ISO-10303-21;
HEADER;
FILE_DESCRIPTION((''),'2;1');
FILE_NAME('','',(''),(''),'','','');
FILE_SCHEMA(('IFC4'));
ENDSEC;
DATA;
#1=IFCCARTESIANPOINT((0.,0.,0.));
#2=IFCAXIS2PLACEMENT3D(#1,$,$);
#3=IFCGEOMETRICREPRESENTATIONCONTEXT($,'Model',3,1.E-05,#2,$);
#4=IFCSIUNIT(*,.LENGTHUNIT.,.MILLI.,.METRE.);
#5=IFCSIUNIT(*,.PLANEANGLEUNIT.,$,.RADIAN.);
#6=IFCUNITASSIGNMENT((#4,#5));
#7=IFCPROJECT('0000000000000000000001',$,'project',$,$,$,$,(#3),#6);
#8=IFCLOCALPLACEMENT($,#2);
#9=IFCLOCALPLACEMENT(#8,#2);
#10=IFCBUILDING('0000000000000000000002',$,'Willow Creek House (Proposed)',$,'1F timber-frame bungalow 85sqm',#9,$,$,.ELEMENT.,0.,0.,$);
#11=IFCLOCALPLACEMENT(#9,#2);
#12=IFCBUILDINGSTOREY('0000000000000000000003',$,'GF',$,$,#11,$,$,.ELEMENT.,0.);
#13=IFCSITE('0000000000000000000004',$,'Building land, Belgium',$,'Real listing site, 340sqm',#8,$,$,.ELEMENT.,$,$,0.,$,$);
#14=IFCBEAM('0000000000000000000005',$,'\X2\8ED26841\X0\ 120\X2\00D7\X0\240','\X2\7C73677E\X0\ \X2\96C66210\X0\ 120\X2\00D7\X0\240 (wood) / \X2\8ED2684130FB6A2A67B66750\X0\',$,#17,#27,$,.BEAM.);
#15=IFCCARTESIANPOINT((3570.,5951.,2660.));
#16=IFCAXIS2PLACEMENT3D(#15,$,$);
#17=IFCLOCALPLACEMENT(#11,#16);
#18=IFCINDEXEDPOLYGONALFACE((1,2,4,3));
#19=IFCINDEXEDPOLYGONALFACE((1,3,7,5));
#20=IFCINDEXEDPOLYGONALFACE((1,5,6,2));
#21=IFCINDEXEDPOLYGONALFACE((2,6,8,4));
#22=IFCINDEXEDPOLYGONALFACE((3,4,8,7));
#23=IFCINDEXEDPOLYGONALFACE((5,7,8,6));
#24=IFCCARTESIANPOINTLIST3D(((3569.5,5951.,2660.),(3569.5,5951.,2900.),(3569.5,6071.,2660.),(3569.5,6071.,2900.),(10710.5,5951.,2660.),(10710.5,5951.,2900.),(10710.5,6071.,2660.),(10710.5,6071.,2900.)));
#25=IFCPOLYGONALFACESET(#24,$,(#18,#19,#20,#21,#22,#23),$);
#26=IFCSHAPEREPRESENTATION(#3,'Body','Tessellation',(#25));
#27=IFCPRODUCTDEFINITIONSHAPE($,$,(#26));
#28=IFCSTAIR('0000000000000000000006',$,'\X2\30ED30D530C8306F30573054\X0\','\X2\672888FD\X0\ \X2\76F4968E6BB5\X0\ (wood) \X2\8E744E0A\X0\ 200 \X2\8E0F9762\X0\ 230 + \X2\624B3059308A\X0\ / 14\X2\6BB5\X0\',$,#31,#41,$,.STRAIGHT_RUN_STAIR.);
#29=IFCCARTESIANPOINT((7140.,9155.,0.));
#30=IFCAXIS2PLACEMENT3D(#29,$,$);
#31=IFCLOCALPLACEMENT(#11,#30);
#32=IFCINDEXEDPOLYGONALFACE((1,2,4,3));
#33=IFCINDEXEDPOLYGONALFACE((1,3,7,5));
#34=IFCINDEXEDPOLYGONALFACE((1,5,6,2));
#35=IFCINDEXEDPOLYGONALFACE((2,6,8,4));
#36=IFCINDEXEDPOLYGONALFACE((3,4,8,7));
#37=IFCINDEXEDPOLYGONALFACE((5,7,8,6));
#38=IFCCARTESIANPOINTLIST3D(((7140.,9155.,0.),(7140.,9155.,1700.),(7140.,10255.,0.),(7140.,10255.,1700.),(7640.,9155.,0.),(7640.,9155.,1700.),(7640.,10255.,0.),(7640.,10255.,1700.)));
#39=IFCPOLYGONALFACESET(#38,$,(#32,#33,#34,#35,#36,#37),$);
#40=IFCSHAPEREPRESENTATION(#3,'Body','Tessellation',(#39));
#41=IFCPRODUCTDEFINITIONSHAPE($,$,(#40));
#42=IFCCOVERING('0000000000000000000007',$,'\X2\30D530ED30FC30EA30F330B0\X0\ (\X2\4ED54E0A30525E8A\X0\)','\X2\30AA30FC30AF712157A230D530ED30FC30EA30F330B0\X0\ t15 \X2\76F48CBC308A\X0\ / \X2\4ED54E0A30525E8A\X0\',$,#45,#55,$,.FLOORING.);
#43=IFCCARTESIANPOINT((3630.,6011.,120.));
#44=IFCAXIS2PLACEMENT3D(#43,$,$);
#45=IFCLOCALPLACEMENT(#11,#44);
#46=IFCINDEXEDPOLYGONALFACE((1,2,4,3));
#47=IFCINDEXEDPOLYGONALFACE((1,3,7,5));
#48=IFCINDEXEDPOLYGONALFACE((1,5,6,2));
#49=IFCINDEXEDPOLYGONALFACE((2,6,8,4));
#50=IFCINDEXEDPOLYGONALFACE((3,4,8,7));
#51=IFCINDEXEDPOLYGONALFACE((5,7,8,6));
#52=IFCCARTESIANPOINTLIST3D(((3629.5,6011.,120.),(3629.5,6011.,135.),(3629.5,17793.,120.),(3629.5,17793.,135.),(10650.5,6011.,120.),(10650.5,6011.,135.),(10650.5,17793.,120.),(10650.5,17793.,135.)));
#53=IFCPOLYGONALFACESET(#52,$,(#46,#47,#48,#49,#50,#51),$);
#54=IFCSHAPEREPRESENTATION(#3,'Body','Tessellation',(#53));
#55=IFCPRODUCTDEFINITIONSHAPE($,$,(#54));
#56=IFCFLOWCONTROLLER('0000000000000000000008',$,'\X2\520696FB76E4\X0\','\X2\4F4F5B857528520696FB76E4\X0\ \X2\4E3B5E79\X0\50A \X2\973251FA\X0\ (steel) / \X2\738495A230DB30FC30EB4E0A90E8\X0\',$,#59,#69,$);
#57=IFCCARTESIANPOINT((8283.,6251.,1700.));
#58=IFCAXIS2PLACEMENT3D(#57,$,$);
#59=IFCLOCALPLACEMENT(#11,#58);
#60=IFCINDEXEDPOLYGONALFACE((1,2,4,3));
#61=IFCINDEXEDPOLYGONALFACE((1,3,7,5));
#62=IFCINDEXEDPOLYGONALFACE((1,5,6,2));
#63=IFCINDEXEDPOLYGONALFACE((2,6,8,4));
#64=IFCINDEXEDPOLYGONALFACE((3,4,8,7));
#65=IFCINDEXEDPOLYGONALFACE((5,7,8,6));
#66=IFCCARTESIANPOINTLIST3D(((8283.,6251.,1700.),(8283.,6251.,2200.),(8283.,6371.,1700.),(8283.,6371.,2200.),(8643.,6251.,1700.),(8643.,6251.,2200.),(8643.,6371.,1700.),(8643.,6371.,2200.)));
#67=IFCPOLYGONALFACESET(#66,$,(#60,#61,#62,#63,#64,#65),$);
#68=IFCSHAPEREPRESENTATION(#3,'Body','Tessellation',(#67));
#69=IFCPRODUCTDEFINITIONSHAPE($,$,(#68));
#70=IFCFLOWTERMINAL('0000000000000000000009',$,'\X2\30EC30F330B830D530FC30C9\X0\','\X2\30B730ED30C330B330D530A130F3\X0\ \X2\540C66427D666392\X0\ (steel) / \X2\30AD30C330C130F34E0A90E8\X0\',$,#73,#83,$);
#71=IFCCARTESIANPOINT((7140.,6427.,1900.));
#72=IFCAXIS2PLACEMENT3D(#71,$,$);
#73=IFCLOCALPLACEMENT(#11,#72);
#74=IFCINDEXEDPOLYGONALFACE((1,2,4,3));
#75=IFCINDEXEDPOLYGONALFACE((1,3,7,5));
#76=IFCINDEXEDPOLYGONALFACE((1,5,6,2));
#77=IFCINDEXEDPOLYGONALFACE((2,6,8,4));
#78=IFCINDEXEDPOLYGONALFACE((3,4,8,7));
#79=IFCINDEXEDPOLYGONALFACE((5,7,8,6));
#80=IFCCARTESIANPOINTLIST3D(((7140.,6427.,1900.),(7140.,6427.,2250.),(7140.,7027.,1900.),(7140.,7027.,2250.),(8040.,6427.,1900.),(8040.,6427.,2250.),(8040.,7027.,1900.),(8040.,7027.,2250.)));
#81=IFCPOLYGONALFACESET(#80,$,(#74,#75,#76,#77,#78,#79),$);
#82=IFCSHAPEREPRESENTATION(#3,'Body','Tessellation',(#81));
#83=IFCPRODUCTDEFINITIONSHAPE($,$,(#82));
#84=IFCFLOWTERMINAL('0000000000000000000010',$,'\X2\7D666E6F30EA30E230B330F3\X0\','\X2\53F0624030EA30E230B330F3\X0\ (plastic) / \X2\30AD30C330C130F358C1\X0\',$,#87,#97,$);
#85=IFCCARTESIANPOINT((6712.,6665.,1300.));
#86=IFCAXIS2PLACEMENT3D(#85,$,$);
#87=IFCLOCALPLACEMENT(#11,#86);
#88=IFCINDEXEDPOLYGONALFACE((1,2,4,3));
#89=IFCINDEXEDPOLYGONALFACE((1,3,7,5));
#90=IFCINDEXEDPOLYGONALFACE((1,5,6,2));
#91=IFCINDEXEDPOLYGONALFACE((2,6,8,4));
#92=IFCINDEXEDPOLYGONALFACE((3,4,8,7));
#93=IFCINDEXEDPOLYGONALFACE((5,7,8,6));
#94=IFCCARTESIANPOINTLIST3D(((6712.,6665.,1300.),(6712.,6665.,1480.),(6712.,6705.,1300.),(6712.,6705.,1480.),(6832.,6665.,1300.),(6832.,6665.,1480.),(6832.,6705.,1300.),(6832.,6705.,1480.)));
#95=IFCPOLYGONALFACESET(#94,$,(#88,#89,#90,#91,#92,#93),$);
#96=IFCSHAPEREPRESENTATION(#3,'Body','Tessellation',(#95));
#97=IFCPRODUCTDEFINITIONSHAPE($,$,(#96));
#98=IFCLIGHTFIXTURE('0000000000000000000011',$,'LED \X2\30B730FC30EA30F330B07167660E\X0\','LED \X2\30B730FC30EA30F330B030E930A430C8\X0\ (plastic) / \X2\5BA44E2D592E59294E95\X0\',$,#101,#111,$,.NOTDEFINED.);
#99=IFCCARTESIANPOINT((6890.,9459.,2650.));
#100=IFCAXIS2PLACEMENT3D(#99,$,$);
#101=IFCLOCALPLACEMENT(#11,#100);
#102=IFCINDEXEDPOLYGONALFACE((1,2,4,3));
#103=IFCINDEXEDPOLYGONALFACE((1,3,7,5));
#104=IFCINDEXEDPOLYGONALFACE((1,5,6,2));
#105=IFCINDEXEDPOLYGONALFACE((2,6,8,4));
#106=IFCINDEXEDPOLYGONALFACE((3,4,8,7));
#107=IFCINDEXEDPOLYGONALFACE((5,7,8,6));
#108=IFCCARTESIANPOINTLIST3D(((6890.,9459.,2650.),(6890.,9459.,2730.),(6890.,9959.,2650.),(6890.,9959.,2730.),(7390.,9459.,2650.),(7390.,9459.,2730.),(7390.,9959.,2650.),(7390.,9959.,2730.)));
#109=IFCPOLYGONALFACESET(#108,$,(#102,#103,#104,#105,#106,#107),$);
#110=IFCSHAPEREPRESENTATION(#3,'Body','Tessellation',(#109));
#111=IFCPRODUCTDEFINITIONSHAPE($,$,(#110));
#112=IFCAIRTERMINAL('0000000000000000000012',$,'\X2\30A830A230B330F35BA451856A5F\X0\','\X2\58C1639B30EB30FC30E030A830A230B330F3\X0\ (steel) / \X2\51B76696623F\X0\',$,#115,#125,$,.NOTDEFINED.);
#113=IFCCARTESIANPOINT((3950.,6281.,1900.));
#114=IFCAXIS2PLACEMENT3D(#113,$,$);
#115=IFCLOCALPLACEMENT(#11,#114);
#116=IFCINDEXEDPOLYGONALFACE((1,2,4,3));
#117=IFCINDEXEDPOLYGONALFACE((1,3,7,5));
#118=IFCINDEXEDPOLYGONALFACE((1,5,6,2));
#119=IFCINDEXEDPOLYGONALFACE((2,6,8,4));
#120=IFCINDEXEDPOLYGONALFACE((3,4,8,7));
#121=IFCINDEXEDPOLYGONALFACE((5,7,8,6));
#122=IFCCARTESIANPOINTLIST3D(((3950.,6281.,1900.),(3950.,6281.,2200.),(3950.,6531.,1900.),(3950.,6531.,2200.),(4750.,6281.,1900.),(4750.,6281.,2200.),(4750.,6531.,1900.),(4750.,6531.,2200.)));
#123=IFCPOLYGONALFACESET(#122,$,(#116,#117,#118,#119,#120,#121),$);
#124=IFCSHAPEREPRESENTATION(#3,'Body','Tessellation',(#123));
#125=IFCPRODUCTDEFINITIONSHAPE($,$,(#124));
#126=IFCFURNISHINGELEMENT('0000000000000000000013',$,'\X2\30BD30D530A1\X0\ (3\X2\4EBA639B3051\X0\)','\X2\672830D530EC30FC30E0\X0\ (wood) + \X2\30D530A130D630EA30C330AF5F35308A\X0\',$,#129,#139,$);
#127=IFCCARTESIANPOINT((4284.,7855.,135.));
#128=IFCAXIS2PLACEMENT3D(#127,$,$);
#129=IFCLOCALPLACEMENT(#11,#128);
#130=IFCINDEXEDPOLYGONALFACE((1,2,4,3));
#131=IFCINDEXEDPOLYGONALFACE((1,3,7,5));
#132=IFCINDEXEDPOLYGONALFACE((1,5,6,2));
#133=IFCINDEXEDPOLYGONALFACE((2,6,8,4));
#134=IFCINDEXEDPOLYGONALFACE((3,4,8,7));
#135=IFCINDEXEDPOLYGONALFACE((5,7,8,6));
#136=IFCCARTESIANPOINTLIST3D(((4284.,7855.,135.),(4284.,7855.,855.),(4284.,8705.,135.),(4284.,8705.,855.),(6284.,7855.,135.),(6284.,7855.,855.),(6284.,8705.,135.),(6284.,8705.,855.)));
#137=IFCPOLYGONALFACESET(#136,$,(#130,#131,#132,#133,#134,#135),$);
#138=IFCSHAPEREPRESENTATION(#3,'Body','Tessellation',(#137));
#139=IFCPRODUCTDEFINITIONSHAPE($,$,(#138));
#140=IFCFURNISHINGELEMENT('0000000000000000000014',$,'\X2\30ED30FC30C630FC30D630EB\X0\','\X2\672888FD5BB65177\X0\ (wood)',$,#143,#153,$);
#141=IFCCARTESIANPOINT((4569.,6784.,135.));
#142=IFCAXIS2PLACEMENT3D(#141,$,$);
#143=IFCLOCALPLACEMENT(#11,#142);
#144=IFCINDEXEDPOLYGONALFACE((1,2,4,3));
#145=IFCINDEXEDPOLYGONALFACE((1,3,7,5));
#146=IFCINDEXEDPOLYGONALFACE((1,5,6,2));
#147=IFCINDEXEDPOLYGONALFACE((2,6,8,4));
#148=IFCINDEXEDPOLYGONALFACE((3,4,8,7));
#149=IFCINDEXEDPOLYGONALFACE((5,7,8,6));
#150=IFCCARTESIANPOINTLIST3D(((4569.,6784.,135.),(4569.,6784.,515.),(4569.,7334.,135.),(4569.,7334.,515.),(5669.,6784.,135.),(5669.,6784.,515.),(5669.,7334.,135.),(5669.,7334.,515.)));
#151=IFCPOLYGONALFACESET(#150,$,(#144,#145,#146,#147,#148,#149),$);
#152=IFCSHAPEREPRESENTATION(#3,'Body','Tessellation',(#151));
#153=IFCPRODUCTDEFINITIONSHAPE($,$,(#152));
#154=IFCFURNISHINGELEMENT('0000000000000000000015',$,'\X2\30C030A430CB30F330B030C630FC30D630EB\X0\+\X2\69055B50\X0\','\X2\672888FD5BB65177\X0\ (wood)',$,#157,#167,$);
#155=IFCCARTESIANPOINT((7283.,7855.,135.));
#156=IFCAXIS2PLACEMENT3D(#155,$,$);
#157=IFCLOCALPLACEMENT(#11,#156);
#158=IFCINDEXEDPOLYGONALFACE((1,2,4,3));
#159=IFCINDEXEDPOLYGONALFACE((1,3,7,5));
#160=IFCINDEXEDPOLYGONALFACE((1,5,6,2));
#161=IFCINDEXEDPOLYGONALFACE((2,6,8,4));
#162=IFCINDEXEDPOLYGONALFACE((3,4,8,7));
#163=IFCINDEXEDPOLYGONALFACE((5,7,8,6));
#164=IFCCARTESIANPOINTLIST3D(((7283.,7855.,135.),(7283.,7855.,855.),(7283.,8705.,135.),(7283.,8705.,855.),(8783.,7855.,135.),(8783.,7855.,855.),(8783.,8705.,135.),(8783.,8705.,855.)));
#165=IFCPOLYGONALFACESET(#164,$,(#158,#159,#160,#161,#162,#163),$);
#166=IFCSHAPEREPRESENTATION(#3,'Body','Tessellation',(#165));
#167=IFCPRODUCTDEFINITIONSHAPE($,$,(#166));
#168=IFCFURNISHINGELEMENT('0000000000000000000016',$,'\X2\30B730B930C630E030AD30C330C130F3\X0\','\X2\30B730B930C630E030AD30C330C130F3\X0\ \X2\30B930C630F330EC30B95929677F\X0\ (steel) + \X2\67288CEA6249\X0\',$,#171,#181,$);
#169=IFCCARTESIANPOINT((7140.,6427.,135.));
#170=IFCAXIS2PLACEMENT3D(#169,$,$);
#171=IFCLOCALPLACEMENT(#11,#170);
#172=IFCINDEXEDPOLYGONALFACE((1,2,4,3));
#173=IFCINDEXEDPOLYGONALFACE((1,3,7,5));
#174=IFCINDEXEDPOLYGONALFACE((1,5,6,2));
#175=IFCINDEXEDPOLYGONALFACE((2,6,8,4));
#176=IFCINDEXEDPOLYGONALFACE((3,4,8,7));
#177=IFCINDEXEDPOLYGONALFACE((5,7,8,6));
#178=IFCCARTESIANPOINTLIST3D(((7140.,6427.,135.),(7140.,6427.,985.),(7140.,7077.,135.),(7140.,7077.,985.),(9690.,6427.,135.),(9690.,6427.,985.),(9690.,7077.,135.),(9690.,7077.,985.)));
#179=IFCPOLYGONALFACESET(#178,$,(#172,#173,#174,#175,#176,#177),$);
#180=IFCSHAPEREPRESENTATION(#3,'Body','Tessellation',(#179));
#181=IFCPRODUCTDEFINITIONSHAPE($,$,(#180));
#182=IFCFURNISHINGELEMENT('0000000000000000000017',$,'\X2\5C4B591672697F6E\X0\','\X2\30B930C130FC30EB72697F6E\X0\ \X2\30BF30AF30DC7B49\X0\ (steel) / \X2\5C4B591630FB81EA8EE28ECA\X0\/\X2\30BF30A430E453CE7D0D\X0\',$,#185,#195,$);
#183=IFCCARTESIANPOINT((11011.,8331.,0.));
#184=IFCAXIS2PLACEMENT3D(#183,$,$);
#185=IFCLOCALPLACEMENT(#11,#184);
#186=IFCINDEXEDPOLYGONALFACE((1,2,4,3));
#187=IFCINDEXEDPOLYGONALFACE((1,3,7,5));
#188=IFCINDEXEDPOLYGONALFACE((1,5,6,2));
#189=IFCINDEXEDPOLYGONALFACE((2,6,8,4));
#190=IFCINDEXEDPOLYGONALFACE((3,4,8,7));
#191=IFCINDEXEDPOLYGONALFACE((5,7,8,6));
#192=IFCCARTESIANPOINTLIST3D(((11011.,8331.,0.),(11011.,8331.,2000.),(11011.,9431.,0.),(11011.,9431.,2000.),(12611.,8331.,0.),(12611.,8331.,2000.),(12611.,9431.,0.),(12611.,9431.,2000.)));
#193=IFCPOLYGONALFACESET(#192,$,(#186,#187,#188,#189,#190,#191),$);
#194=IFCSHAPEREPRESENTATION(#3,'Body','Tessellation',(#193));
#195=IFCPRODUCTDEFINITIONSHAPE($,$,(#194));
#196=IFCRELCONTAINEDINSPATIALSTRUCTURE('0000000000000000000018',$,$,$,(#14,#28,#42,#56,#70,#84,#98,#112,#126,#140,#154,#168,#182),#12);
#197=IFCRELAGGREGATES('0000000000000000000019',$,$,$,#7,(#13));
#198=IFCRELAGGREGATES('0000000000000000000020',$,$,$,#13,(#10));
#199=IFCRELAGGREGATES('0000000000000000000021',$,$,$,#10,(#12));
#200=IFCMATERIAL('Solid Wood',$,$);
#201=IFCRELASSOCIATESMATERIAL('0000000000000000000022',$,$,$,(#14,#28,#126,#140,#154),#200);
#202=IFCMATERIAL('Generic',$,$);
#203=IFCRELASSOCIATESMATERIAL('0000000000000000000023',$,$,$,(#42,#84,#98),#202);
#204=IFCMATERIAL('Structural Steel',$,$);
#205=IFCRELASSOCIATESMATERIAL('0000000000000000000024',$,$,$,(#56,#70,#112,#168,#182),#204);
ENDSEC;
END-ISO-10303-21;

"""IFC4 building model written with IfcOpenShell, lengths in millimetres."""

from ifc_helpers import new_model, si_unit, frame, frame_2d, origin, place, context, project, spatial, rectangle, extrude, material, element, save


model = new_model("IFC4")

# Units and contexts
model_context = context("Model", 3, precision=1e-05, world=origin())
ifc_project = project(units=[si_unit("LENGTHUNIT", "METRE", prefix="MILLI"), si_unit("PLANEANGLEUNIT", "RADIAN")], contexts=[model_context])

# Site, building, storey
site_placement = place(None, origin())
site = spatial("IfcSite", under=ifc_project, at=site_placement, Name="Building land, Belgium", ObjectType="Real listing site, 340sqm", CompositionType="ELEMENT", RefElevation=0.0)
building_placement = place(site_placement, origin())
building = spatial("IfcBuilding", under=site, at=building_placement, Name="Willow Creek House (Proposed)", ObjectType="1F timber-frame bungalow 85sqm", CompositionType="ELEMENT", ElevationOfRefHeight=0.0, ElevationOfTerrain=0.0)
storey_placement = place(building_placement, origin())
storey = spatial("IfcBuildingStorey", under=building, at=storey_placement, Name="GF", CompositionType="ELEMENT", Elevation=0.0)

# Shared definitions
ifc_material_1 = material(Name="Solid Wood")

# Beam
beam_1_placement = place(storey_placement, frame((3570.0, 5951.0, 2660.0)))
element("IfcBeam", 1, at=beam_1_placement, inside=storey, material=ifc_material_1, Name="軒桁 120×240", Description="米松 集成 120×240 (wood) / 軒桁・横架材", PredefinedType="BEAM", context=model_context, shape_type="SweptSolid", body=[
    extrude(rectangle(XDim=7141.0, YDim=120.0, at=frame_2d((3570.0, 60.0))), frame((3570.0, 5951.0, 2660.0)), (0.0, 0.0, 1.0), 240.0),
])

# Stair
stair_placement = place(storey_placement, frame((7140.0, 9155.0, 0.0)))
element("IfcStair", 2, at=stair_placement, inside=storey, material=ifc_material_1, Name="ロフトはしご", Description="木製 直階段 (wood) 蹴上 200 踏面 230 + 手すり / 14段", PredefinedType="STRAIGHT_RUN_STAIR", context=model_context, shape_type="SweptSolid", body=[
    extrude(rectangle(XDim=500.0, YDim=1100.0, at=frame_2d((250.0, 550.0))), frame((7140.0, 9155.0, 0.0)), (0.0, 0.0, 1.0), 1700.0),
])

# Covering
ifc_material_2 = material(Name="Generic")
covering_placement = place(storey_placement, frame((3630.0, 6011.0, 120.0)))
element("IfcCovering", 3, at=covering_placement, inside=storey, material=ifc_material_2, Name="フローリング (仕上げ床)", Description="オーク無垢フローリング t15 直貼り / 仕上げ床", PredefinedType="FLOORING", context=model_context, shape_type="SweptSolid", body=[
    extrude(rectangle(XDim=7021.0, YDim=11782.0, at=frame_2d((3510.0, 5891.0))), frame((3630.0, 6011.0, 120.0)), (0.0, 0.0, 1.0), 15.0),
])

# Flow controller
ifc_material_3 = material(Name="Structural Steel")
flow_controller_placement = place(storey_placement, frame((8283.0, 6251.0, 1700.0)))
element("IfcFlowController", 4, at=flow_controller_placement, inside=storey, material=ifc_material_3, Name="分電盤", Description="住宅用分電盤 主幹50A 露出 (steel) / 玄関ホール上部", context=model_context, shape_type="SweptSolid", body=[
    extrude(rectangle(XDim=360.0, YDim=120.0, at=frame_2d((180.0, 60.0))), frame((8283.0, 6251.0, 1700.0)), (0.0, 0.0, 1.0), 500.0),
])

# Flow terminals
flow_terminal_1_placement = place(storey_placement, frame((7140.0, 6427.0, 1900.0)))
element("IfcFlowTerminal", 5, at=flow_terminal_1_placement, inside=storey, material=ifc_material_3, Name="レンジフード", Description="シロッコファン 同時給排 (steel) / キッチン上部", context=model_context, shape_type="SweptSolid", body=[
    extrude(rectangle(XDim=900.0, YDim=600.0, at=frame_2d((450.0, 300.0))), frame((7140.0, 6427.0, 1900.0)), (0.0, 0.0, 1.0), 350.0),
])
flow_terminal_2_placement = place(storey_placement, frame((6712.0, 6665.0, 1300.0)))
element("IfcFlowTerminal", 6, at=flow_terminal_2_placement, inside=storey, material=ifc_material_2, Name="給湯リモコン", Description="台所リモコン (plastic) / キッチン壁", context=model_context, shape_type="SweptSolid", body=[
    extrude(rectangle(XDim=120.0, YDim=40.0, at=frame_2d((60.0, 20.0))), frame((6712.0, 6665.0, 1300.0)), (0.0, 0.0, 1.0), 180.0),
])

# Light fixture
light_fixture_placement = place(storey_placement, frame((6890.0, 9459.0, 2650.0)))
element("IfcLightFixture", 7, at=light_fixture_placement, inside=storey, material=ifc_material_2, Name="LED シーリング照明", Description="LED シーリングライト (plastic) / 室中央天井", PredefinedType="NOTDEFINED", context=model_context, shape_type="SweptSolid", body=[
    extrude(rectangle(XDim=500.0, YDim=500.0, at=frame_2d((250.0, 250.0))), frame((6890.0, 9459.0, 2650.0)), (0.0, 0.0, 1.0), 80.0),
])

# Air terminal
air_terminal_placement = place(storey_placement, frame((3950.0, 6281.0, 1900.0)))
element("IfcAirTerminal", 8, at=air_terminal_placement, inside=storey, material=ifc_material_3, Name="エアコン室内機", Description="壁掛ルームエアコン (steel) / 冷暖房", PredefinedType="NOTDEFINED", context=model_context, shape_type="SweptSolid", body=[
    extrude(rectangle(XDim=800.0, YDim=250.0, at=frame_2d((400.0, 125.0))), frame((3950.0, 6281.0, 1900.0)), (0.0, 0.0, 1.0), 300.0),
])

# Furnishing elements
furnishing_1_placement = place(storey_placement, frame((4284.0, 7855.0, 135.0)))
element("IfcFurnishingElement", 9, at=furnishing_1_placement, inside=storey, material=ifc_material_1, Name="ソファ (3人掛け)", Description="木フレーム (wood) + ファブリック張り", context=model_context, shape_type="SweptSolid", body=[
    extrude(rectangle(XDim=2000.0, YDim=850.0, at=frame_2d((1000.0, 425.0))), frame((4284.0, 7855.0, 135.0)), (0.0, 0.0, 1.0), 720.0),
])
furnishing_2_placement = place(storey_placement, frame((4569.0, 6784.0, 135.0)))
element("IfcFurnishingElement", 10, at=furnishing_2_placement, inside=storey, material=ifc_material_1, Name="ローテーブル", Description="木製家具 (wood)", context=model_context, shape_type="SweptSolid", body=[
    extrude(rectangle(XDim=1100.0, YDim=550.0, at=frame_2d((550.0, 275.0))), frame((4569.0, 6784.0, 135.0)), (0.0, 0.0, 1.0), 380.0),
])
furnishing_3_placement = place(storey_placement, frame((7283.0, 7855.0, 135.0)))
element("IfcFurnishingElement", 11, at=furnishing_3_placement, inside=storey, material=ifc_material_1, Name="ダイニングテーブル+椅子", Description="木製家具 (wood)", context=model_context, shape_type="SweptSolid", body=[
    extrude(rectangle(XDim=1500.0, YDim=850.0, at=frame_2d((750.0, 425.0))), frame((7283.0, 7855.0, 135.0)), (0.0, 0.0, 1.0), 720.0),
])
furnishing_4_placement = place(storey_placement, frame((7140.0, 6427.0, 135.0)))
element("IfcFurnishingElement", 12, at=furnishing_4_placement, inside=storey, material=ifc_material_3, Name="システムキッチン", Description="システムキッチン ステンレス天板 (steel) + 木質扉", context=model_context, shape_type="SweptSolid", body=[
    extrude(rectangle(XDim=2550.0, YDim=650.0, at=frame_2d((1275.0, 325.0))), frame((7140.0, 6427.0, 135.0)), (0.0, 0.0, 1.0), 850.0),
])
furnishing_5_placement = place(storey_placement, frame((11011.0, 8331.0, 0.0)))
element("IfcFurnishingElement", 13, at=furnishing_5_placement, inside=storey, material=ifc_material_3, Name="屋外物置", Description="スチール物置 タクボ等 (steel) / 屋外・自転車/タイヤ収納", context=model_context, shape_type="SweptSolid", body=[
    extrude(rectangle(XDim=1600.0, YDim=1100.0, at=frame_2d((800.0, 550.0))), frame((11011.0, 8331.0, 0.0)), (0.0, 0.0, 1.0), 2000.0),
])

save(model, "model.ifc")
